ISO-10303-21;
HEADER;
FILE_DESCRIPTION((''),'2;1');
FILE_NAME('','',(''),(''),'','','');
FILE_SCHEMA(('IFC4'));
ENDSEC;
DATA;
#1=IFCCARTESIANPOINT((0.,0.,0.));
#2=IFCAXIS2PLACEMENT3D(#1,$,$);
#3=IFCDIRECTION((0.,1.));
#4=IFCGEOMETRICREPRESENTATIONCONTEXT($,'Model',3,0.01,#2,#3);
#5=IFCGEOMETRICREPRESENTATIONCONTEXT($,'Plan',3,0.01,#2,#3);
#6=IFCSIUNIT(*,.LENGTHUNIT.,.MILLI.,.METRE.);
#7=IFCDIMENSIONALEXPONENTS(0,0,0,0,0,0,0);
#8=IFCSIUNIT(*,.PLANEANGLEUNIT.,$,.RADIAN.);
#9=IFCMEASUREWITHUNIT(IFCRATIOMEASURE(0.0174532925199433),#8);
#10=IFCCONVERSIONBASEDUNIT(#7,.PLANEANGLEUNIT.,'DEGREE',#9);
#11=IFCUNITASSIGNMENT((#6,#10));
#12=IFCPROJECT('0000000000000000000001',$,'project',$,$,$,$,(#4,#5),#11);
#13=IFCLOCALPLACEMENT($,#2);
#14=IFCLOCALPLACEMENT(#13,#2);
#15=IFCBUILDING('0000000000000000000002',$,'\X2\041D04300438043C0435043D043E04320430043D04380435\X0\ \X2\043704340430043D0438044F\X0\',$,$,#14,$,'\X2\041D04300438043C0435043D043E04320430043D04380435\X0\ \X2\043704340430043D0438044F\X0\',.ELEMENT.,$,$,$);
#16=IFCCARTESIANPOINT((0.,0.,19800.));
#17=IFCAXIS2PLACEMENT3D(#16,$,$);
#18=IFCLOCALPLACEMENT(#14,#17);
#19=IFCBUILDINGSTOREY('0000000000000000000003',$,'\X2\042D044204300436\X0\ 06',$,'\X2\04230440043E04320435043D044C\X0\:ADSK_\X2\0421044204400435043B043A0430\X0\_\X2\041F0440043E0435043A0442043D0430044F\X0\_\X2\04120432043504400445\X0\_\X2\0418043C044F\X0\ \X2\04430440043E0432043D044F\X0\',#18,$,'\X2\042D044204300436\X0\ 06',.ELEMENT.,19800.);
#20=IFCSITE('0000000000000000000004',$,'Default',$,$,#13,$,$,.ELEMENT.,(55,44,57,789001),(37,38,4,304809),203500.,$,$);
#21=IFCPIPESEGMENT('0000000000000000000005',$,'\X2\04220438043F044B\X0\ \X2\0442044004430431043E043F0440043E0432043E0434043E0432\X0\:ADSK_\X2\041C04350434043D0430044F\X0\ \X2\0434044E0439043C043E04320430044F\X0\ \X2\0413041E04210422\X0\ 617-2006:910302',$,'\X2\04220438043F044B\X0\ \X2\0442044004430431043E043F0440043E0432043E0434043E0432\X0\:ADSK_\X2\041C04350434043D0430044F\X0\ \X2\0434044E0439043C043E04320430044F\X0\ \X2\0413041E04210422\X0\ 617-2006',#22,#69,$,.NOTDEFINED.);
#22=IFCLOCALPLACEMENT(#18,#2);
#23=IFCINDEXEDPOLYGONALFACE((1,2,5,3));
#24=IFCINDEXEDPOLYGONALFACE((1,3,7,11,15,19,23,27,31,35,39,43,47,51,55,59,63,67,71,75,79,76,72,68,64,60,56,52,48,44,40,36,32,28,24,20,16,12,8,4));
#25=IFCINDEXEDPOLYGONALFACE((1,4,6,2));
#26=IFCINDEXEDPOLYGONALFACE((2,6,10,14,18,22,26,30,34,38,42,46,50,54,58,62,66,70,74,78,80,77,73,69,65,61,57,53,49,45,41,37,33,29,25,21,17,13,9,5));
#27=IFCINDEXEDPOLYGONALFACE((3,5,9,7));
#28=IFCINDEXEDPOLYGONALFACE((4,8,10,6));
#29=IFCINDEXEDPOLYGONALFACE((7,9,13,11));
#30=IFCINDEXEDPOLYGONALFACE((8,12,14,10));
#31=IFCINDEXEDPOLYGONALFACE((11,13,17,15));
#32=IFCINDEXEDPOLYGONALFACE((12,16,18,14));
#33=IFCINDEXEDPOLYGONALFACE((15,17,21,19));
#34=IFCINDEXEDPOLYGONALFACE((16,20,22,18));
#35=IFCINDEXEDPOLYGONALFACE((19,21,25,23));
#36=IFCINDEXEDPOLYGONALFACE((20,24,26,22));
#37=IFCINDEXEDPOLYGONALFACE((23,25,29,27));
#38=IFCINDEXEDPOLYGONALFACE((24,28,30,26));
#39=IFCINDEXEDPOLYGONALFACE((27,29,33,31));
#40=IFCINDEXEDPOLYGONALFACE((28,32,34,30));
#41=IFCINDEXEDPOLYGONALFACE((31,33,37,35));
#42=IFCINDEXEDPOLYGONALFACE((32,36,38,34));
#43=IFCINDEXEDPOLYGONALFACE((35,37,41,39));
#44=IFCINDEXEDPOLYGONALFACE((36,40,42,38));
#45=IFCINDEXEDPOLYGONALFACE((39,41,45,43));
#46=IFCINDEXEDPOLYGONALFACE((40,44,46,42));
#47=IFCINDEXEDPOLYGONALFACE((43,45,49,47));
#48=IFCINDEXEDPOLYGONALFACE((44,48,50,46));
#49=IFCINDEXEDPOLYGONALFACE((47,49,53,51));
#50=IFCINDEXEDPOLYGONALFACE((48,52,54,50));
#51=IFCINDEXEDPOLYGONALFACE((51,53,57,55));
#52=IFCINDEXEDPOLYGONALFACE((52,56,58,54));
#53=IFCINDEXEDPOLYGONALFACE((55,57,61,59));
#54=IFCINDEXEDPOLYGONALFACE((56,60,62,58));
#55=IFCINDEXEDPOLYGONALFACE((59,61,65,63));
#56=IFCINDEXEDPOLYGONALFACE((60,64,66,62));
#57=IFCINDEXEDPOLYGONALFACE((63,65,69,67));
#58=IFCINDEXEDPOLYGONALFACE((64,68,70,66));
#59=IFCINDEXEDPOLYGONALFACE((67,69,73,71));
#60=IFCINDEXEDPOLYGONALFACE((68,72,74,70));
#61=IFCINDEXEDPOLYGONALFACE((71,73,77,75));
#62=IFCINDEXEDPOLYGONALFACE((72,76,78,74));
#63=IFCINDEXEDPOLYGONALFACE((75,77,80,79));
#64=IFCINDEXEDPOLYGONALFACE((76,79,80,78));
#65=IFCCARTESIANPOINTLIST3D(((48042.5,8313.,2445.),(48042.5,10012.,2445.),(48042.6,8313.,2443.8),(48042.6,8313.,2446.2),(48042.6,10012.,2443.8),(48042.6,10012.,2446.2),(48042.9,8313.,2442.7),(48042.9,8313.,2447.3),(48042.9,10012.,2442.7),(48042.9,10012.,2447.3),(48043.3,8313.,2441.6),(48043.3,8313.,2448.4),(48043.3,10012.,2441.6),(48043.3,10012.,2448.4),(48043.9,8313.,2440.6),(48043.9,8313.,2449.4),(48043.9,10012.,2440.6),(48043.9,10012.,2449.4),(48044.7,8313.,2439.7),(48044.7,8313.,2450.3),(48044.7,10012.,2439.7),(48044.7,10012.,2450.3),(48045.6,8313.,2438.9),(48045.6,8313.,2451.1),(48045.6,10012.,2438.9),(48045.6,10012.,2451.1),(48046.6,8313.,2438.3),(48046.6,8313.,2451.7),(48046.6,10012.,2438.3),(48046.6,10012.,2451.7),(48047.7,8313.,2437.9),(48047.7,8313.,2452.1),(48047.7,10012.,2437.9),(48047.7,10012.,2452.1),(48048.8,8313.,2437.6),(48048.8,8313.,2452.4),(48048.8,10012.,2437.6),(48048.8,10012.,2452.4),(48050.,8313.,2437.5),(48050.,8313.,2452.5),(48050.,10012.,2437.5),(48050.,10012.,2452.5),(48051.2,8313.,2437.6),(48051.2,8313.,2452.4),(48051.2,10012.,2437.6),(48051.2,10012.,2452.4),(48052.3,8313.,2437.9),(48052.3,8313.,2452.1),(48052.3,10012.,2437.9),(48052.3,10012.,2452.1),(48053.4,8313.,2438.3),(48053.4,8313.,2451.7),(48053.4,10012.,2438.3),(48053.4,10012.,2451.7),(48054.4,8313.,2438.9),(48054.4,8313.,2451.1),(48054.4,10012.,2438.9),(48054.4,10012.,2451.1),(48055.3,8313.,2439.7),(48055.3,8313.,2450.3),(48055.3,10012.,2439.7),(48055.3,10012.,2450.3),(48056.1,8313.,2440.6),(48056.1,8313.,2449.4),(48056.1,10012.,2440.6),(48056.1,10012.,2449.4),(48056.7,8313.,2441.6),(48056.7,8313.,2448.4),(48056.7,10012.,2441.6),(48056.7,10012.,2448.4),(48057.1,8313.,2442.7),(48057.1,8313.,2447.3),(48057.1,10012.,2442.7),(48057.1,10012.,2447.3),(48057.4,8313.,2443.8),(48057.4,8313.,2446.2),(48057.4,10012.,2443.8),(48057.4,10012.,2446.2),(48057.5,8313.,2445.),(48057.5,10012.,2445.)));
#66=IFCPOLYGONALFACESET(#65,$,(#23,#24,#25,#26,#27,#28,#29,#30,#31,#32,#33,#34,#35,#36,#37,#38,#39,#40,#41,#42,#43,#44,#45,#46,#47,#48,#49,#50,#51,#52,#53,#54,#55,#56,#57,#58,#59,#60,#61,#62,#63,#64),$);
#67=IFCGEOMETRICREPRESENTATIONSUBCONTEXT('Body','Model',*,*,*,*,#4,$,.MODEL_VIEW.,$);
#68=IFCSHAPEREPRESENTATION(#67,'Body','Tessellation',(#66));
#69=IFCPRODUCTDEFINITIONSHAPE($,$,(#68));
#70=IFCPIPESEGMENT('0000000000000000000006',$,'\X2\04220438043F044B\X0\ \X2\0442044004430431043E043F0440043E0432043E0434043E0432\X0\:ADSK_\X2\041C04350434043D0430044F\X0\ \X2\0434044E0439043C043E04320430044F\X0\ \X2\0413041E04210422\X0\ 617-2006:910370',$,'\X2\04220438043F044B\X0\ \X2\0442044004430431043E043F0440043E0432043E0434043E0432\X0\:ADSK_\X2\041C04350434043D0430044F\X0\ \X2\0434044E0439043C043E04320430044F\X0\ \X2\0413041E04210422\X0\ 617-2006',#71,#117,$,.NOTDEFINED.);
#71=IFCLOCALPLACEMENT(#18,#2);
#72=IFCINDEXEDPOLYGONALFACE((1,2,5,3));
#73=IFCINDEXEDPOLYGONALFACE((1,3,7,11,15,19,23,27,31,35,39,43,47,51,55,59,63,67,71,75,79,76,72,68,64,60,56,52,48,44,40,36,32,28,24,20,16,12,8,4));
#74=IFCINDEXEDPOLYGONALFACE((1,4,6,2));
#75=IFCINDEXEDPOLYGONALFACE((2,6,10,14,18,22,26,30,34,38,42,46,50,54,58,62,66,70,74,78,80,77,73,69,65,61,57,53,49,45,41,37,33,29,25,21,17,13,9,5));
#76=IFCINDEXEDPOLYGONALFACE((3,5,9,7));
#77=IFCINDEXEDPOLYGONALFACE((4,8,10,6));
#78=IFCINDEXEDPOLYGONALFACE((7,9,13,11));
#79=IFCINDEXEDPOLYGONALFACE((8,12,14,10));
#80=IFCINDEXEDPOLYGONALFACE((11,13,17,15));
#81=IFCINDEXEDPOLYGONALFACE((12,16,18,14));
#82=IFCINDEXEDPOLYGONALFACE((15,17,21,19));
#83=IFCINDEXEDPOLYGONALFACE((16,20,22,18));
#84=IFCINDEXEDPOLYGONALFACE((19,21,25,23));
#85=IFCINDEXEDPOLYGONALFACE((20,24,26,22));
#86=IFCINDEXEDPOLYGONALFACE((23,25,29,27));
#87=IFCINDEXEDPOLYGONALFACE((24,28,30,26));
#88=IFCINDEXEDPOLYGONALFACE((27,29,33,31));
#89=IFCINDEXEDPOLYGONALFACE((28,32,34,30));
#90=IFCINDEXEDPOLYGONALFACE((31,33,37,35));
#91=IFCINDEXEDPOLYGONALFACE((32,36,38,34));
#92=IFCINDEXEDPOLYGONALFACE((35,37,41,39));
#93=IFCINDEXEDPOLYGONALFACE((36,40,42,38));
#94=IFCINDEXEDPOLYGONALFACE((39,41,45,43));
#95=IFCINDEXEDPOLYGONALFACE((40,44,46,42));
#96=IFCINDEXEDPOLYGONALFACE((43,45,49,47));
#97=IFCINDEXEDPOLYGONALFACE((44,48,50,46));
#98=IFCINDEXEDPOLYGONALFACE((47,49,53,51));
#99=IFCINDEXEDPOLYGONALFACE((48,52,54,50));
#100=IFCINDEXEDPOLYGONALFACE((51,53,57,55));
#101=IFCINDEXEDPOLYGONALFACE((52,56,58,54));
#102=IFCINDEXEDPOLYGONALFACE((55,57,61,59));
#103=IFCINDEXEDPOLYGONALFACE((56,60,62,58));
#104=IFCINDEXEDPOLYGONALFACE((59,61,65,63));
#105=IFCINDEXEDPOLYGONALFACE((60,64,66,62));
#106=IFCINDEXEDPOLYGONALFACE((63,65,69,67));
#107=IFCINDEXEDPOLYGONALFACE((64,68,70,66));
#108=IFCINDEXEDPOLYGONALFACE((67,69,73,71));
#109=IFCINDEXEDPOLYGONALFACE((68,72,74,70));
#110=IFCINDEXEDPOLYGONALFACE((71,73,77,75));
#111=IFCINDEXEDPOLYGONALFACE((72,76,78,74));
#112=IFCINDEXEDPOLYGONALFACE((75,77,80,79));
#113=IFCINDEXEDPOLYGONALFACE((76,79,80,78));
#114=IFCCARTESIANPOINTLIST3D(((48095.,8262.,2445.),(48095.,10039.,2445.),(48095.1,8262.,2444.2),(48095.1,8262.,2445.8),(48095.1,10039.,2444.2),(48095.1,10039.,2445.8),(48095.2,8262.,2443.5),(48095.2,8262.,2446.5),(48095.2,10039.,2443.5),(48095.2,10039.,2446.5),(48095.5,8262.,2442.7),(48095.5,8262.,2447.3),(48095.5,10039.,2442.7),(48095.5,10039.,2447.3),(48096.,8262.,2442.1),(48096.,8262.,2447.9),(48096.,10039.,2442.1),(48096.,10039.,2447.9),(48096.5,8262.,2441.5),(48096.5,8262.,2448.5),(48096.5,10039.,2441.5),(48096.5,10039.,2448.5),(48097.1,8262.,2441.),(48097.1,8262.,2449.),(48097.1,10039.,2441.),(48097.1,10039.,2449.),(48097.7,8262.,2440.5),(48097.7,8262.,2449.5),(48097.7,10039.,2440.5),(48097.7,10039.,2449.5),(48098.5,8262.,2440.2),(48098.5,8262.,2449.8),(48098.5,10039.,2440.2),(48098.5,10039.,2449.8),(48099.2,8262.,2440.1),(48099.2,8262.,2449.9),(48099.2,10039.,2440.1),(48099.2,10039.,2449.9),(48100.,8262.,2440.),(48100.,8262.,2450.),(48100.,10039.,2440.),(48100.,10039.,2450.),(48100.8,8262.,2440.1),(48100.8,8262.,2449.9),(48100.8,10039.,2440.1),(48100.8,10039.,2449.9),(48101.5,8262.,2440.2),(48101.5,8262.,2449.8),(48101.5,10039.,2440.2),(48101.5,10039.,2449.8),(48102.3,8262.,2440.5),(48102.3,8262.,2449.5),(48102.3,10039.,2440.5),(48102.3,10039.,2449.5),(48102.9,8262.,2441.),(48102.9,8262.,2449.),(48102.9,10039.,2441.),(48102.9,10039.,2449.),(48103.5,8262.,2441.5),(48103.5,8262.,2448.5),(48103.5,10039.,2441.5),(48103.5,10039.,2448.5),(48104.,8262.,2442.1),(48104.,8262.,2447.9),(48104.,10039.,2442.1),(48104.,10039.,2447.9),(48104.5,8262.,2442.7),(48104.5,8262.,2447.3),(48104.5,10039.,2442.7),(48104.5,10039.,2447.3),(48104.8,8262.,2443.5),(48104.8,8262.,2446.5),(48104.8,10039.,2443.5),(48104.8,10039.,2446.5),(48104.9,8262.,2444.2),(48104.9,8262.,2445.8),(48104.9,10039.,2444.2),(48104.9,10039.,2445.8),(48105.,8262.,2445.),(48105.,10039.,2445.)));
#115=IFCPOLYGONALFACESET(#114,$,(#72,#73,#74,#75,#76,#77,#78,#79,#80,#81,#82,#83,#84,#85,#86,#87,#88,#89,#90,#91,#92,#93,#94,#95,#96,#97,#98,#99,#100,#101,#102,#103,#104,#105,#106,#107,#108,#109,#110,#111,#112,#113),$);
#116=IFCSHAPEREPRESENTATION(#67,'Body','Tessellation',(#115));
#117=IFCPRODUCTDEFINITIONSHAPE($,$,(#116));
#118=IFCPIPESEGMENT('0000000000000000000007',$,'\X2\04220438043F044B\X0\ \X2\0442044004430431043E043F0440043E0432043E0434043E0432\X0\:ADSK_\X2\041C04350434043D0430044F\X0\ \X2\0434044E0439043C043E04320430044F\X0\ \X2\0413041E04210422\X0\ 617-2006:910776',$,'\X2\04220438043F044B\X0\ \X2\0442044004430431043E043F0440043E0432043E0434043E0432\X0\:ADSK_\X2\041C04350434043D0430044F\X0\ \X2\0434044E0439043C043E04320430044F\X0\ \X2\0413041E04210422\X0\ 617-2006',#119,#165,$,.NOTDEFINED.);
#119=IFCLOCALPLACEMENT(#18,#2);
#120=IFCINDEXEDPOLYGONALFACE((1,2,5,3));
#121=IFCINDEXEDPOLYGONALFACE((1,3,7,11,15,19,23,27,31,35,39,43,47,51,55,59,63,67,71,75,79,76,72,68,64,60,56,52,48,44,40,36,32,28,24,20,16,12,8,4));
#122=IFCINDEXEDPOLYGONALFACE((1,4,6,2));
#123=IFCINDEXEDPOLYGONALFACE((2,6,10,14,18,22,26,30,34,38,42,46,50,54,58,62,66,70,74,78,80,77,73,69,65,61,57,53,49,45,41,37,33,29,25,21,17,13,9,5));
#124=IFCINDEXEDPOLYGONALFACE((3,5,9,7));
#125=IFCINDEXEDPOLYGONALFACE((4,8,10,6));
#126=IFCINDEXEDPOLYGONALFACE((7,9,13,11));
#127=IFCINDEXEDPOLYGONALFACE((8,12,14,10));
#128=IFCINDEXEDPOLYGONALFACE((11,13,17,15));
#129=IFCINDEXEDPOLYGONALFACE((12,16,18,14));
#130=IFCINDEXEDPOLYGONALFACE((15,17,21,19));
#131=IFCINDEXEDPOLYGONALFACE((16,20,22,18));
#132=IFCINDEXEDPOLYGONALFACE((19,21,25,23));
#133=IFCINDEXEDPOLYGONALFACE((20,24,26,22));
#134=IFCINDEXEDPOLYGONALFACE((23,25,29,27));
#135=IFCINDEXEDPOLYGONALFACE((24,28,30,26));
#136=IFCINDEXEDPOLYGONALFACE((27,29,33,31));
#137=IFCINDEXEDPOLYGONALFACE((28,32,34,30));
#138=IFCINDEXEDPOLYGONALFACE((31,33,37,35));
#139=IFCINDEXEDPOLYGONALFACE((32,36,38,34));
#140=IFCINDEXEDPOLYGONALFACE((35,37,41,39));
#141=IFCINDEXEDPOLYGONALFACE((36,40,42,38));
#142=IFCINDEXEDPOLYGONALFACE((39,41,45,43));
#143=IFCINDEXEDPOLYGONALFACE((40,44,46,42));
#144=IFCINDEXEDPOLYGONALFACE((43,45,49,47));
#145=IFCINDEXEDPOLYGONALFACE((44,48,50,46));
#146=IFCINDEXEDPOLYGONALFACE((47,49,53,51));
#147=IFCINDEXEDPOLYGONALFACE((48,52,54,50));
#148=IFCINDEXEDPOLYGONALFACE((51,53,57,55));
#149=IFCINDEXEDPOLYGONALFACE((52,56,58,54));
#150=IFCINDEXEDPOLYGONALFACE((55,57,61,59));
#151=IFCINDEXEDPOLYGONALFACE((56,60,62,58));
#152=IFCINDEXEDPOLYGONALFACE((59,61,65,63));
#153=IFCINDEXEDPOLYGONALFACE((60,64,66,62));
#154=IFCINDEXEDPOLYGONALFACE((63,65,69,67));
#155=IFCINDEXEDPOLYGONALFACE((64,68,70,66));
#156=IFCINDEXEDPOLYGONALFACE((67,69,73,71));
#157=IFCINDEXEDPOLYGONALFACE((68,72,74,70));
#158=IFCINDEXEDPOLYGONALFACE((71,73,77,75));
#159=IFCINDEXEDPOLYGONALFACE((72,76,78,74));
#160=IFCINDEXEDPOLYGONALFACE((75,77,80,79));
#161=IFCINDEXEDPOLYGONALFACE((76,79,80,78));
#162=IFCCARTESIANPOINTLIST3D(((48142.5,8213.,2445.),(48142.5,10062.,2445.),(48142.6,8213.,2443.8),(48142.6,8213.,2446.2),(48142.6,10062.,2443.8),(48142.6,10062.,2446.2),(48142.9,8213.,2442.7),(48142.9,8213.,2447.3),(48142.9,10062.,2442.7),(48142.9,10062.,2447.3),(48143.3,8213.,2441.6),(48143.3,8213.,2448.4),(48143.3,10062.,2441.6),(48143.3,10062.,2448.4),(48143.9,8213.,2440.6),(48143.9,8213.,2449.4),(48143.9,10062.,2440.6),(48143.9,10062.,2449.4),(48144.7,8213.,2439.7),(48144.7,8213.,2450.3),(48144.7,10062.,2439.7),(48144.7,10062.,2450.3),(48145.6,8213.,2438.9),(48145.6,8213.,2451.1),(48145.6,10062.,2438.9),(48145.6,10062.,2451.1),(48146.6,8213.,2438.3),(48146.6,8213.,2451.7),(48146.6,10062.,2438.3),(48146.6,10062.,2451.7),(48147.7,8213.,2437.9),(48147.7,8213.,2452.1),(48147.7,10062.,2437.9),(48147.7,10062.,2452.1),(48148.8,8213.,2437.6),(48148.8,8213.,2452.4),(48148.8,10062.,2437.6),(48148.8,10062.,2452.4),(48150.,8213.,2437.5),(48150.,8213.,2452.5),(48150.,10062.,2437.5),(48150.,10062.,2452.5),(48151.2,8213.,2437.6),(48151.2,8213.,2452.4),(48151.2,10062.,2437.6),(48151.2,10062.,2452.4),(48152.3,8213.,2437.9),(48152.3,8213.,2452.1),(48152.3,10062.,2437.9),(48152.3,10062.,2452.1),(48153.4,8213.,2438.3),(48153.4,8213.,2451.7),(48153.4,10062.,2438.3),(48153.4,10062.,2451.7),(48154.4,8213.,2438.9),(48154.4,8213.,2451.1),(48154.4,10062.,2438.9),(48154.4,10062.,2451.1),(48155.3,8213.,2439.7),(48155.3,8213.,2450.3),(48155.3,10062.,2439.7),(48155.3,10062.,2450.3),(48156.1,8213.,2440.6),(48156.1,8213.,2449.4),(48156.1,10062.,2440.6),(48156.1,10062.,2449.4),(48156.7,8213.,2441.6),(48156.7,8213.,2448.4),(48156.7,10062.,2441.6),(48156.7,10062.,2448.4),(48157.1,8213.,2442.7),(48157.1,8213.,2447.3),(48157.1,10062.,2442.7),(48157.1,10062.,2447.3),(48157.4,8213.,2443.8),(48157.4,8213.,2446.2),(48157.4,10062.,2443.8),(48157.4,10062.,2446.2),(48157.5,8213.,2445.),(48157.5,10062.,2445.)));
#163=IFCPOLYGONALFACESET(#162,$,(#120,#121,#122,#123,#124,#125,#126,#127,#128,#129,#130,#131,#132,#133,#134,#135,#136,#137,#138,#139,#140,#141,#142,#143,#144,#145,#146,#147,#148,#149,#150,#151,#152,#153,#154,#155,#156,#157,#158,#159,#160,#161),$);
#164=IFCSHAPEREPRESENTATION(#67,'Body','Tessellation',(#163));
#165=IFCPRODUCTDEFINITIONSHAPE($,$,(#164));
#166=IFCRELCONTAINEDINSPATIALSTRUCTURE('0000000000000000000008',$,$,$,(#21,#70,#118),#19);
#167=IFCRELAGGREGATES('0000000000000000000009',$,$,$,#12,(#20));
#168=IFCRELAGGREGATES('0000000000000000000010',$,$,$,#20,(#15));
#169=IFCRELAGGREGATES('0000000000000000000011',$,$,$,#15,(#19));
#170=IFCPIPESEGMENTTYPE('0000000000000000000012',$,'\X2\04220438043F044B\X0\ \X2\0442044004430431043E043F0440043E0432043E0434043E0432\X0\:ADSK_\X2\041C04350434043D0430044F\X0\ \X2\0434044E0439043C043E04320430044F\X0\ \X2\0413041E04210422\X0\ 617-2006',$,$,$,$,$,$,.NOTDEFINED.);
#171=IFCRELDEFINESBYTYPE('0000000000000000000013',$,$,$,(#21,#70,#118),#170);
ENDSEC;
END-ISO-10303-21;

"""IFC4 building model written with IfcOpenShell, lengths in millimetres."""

from ifc_helpers import new_model, entity, si_unit, converted_unit, direction, frame, origin, place, context, subcontext, project, spatial, indexed_curve, outline, extrude, type_object, element, save


model = new_model("IFC4")

# Units and contexts
model_context = context("Model", 3, precision=0.01, world=origin(), true_north=direction((0.0, 1.0)))
plan_context = context("Plan", 3, precision=0.01, world=origin(), true_north=direction((0.0, 1.0)))
body_context = subcontext(model_context, "Body", "Model", "MODEL_VIEW")
ifc_project = project(units=[si_unit("LENGTHUNIT", "METRE", prefix="MILLI"), converted_unit("PLANEANGLEUNIT", "DEGREE", entity("IfcRatioMeasure", 0.0174532925199433), si_unit("PLANEANGLEUNIT", "RADIAN"), dimensions=[0, 0, 0, 0, 0, 0, 0])], contexts=[model_context, plan_context])

# Site, building, storey
site_placement = place(None, origin())
site = spatial("IfcSite", under=ifc_project, at=site_placement, Name="Default", CompositionType="ELEMENT", RefLatitude=(55, 44, 57, 789001), RefLongitude=(37, 38, 4, 304809), RefElevation=203500.0)
building_placement = place(site_placement, origin())
building = spatial("IfcBuilding", under=site, at=building_placement, Name="Наименование здания", LongName="Наименование здания", CompositionType="ELEMENT")
storey_placement = place(building_placement, frame((0.0, 0.0, 19800.0)))
storey = spatial("IfcBuildingStorey", under=building, at=storey_placement, Name="Этаж 06", ObjectType="Уровень:ADSK_Стрелка_Проектная_Вверх_Имя уровня", LongName="Этаж 06", CompositionType="ELEMENT", Elevation=19800.0)

# Pipe segments
pipe_segment_type = type_object("IfcPipeSegmentType", Name="Типы трубопроводов:ADSK_Медная дюймовая ГОСТ 617-2006", PredefinedType="NOTDEFINED")
placement = place(storey_placement, origin())
element("IfcPipeSegment", 1, at=placement, inside=storey, type_object=pipe_segment_type, Name="Типы трубопроводов:ADSK_Медная дюймовая ГОСТ 617-2006:910302", ObjectType="Типы трубопроводов:ADSK_Медная дюймовая ГОСТ 617-2006", PredefinedType="NOTDEFINED", context=body_context, shape_type="SweptSolid", body=[
    extrude(outline(indexed_curve([(7.5, 0.0), (7.4, 1.2), (7.1, 2.3), (6.7, 3.4), (6.1, 4.4), (5.3, 5.3), (4.4, 6.1), (3.4, 6.7), (2.3, 7.1), (1.2, 7.4), (0.0, 7.5), (-1.2, 7.4), (-2.3, 7.1), (-3.4, 6.7), (-4.4, 6.1), (-5.3, 5.3), (-6.1, 4.4), (-6.7, 3.4), (-7.1, 2.3), (-7.4, 1.2), (-7.5, 0.0), (-7.4, -1.2), (-7.1, -2.3), (-6.7, -3.4), (-6.1, -4.4), (-5.3, -5.3), (-4.4, -6.1), (-3.4, -6.7), (-2.3, -7.1), (-1.2, -7.4), (0.0, -7.5), (1.2, -7.4), (2.3, -7.1), (3.4, -6.7), (4.4, -6.1), (5.3, -5.3), (6.1, -4.4), (6.7, -3.4), (7.1, -2.3), (7.4, -1.2), (7.5, 0.0)], self_intersect=False)), frame((48050.0, 8313.0, 2445.0), z_axis=(0.0, 1.0, 0.0), x_axis=(1.0, 0.0, 0.0)), (0.0, 0.0, 1.0), 1699.0),
])
element("IfcPipeSegment", 2, at=placement, inside=storey, type_object=pipe_segment_type, Name="Типы трубопроводов:ADSK_Медная дюймовая ГОСТ 617-2006:910370", ObjectType="Типы трубопроводов:ADSK_Медная дюймовая ГОСТ 617-2006", PredefinedType="NOTDEFINED", context=body_context, shape_type="SweptSolid", body=[
    extrude(outline(indexed_curve([(5.0, 0.0), (4.9, 0.8), (4.8, 1.5), (4.5, 2.3), (4.0, 2.9), (3.5, 3.5), (2.9, 4.0), (2.3, 4.5), (1.5, 4.8), (0.8, 4.9), (0.0, 5.0), (-0.8, 4.9), (-1.5, 4.8), (-2.3, 4.5), (-2.9, 4.0), (-3.5, 3.5), (-4.0, 2.9), (-4.5, 2.3), (-4.8, 1.5), (-4.9, 0.8), (-5.0, 0.0), (-4.9, -0.8), (-4.8, -1.5), (-4.5, -2.3), (-4.0, -2.9), (-3.5, -3.5), (-2.9, -4.0), (-2.3, -4.5), (-1.5, -4.8), (-0.8, -4.9), (0.0, -5.0), (0.8, -4.9), (1.5, -4.8), (2.3, -4.5), (2.9, -4.0), (3.5, -3.5), (4.0, -2.9), (4.5, -2.3), (4.8, -1.5), (4.9, -0.8), (5.0, 0.0)], self_intersect=False)), frame((48100.0, 8262.0, 2445.0), z_axis=(0.0, 1.0, 0.0), x_axis=(1.0, 0.0, 0.0)), (0.0, 0.0, 1.0), 1777.0),
])
element("IfcPipeSegment", 3, at=placement, inside=storey, type_object=pipe_segment_type, Name="Типы трубопроводов:ADSK_Медная дюймовая ГОСТ 617-2006:910776", ObjectType="Типы трубопроводов:ADSK_Медная дюймовая ГОСТ 617-2006", PredefinedType="NOTDEFINED", context=body_context, shape_type="SweptSolid", body=[
    extrude(outline(indexed_curve([(7.5, 0.0), (7.4, 1.2), (7.1, 2.3), (6.7, 3.4), (6.1, 4.4), (5.3, 5.3), (4.4, 6.1), (3.4, 6.7), (2.3, 7.1), (1.2, 7.4), (0.0, 7.5), (-1.2, 7.4), (-2.3, 7.1), (-3.4, 6.7), (-4.4, 6.1), (-5.3, 5.3), (-6.1, 4.4), (-6.7, 3.4), (-7.1, 2.3), (-7.4, 1.2), (-7.5, 0.0), (-7.4, -1.2), (-7.1, -2.3), (-6.7, -3.4), (-6.1, -4.4), (-5.3, -5.3), (-4.4, -6.1), (-3.4, -6.7), (-2.3, -7.1), (-1.2, -7.4), (0.0, -7.5), (1.2, -7.4), (2.3, -7.1), (3.4, -6.7), (4.4, -6.1), (5.3, -5.3), (6.1, -4.4), (6.7, -3.4), (7.1, -2.3), (7.4, -1.2), (7.5, 0.0)], self_intersect=False)), frame((48150.0, 8213.0, 2445.0), z_axis=(0.0, 1.0, 0.0), x_axis=(1.0, 0.0, 0.0)), (0.0, 0.0, 1.0), 1849.0),
])

save(model, "model.ifc")
